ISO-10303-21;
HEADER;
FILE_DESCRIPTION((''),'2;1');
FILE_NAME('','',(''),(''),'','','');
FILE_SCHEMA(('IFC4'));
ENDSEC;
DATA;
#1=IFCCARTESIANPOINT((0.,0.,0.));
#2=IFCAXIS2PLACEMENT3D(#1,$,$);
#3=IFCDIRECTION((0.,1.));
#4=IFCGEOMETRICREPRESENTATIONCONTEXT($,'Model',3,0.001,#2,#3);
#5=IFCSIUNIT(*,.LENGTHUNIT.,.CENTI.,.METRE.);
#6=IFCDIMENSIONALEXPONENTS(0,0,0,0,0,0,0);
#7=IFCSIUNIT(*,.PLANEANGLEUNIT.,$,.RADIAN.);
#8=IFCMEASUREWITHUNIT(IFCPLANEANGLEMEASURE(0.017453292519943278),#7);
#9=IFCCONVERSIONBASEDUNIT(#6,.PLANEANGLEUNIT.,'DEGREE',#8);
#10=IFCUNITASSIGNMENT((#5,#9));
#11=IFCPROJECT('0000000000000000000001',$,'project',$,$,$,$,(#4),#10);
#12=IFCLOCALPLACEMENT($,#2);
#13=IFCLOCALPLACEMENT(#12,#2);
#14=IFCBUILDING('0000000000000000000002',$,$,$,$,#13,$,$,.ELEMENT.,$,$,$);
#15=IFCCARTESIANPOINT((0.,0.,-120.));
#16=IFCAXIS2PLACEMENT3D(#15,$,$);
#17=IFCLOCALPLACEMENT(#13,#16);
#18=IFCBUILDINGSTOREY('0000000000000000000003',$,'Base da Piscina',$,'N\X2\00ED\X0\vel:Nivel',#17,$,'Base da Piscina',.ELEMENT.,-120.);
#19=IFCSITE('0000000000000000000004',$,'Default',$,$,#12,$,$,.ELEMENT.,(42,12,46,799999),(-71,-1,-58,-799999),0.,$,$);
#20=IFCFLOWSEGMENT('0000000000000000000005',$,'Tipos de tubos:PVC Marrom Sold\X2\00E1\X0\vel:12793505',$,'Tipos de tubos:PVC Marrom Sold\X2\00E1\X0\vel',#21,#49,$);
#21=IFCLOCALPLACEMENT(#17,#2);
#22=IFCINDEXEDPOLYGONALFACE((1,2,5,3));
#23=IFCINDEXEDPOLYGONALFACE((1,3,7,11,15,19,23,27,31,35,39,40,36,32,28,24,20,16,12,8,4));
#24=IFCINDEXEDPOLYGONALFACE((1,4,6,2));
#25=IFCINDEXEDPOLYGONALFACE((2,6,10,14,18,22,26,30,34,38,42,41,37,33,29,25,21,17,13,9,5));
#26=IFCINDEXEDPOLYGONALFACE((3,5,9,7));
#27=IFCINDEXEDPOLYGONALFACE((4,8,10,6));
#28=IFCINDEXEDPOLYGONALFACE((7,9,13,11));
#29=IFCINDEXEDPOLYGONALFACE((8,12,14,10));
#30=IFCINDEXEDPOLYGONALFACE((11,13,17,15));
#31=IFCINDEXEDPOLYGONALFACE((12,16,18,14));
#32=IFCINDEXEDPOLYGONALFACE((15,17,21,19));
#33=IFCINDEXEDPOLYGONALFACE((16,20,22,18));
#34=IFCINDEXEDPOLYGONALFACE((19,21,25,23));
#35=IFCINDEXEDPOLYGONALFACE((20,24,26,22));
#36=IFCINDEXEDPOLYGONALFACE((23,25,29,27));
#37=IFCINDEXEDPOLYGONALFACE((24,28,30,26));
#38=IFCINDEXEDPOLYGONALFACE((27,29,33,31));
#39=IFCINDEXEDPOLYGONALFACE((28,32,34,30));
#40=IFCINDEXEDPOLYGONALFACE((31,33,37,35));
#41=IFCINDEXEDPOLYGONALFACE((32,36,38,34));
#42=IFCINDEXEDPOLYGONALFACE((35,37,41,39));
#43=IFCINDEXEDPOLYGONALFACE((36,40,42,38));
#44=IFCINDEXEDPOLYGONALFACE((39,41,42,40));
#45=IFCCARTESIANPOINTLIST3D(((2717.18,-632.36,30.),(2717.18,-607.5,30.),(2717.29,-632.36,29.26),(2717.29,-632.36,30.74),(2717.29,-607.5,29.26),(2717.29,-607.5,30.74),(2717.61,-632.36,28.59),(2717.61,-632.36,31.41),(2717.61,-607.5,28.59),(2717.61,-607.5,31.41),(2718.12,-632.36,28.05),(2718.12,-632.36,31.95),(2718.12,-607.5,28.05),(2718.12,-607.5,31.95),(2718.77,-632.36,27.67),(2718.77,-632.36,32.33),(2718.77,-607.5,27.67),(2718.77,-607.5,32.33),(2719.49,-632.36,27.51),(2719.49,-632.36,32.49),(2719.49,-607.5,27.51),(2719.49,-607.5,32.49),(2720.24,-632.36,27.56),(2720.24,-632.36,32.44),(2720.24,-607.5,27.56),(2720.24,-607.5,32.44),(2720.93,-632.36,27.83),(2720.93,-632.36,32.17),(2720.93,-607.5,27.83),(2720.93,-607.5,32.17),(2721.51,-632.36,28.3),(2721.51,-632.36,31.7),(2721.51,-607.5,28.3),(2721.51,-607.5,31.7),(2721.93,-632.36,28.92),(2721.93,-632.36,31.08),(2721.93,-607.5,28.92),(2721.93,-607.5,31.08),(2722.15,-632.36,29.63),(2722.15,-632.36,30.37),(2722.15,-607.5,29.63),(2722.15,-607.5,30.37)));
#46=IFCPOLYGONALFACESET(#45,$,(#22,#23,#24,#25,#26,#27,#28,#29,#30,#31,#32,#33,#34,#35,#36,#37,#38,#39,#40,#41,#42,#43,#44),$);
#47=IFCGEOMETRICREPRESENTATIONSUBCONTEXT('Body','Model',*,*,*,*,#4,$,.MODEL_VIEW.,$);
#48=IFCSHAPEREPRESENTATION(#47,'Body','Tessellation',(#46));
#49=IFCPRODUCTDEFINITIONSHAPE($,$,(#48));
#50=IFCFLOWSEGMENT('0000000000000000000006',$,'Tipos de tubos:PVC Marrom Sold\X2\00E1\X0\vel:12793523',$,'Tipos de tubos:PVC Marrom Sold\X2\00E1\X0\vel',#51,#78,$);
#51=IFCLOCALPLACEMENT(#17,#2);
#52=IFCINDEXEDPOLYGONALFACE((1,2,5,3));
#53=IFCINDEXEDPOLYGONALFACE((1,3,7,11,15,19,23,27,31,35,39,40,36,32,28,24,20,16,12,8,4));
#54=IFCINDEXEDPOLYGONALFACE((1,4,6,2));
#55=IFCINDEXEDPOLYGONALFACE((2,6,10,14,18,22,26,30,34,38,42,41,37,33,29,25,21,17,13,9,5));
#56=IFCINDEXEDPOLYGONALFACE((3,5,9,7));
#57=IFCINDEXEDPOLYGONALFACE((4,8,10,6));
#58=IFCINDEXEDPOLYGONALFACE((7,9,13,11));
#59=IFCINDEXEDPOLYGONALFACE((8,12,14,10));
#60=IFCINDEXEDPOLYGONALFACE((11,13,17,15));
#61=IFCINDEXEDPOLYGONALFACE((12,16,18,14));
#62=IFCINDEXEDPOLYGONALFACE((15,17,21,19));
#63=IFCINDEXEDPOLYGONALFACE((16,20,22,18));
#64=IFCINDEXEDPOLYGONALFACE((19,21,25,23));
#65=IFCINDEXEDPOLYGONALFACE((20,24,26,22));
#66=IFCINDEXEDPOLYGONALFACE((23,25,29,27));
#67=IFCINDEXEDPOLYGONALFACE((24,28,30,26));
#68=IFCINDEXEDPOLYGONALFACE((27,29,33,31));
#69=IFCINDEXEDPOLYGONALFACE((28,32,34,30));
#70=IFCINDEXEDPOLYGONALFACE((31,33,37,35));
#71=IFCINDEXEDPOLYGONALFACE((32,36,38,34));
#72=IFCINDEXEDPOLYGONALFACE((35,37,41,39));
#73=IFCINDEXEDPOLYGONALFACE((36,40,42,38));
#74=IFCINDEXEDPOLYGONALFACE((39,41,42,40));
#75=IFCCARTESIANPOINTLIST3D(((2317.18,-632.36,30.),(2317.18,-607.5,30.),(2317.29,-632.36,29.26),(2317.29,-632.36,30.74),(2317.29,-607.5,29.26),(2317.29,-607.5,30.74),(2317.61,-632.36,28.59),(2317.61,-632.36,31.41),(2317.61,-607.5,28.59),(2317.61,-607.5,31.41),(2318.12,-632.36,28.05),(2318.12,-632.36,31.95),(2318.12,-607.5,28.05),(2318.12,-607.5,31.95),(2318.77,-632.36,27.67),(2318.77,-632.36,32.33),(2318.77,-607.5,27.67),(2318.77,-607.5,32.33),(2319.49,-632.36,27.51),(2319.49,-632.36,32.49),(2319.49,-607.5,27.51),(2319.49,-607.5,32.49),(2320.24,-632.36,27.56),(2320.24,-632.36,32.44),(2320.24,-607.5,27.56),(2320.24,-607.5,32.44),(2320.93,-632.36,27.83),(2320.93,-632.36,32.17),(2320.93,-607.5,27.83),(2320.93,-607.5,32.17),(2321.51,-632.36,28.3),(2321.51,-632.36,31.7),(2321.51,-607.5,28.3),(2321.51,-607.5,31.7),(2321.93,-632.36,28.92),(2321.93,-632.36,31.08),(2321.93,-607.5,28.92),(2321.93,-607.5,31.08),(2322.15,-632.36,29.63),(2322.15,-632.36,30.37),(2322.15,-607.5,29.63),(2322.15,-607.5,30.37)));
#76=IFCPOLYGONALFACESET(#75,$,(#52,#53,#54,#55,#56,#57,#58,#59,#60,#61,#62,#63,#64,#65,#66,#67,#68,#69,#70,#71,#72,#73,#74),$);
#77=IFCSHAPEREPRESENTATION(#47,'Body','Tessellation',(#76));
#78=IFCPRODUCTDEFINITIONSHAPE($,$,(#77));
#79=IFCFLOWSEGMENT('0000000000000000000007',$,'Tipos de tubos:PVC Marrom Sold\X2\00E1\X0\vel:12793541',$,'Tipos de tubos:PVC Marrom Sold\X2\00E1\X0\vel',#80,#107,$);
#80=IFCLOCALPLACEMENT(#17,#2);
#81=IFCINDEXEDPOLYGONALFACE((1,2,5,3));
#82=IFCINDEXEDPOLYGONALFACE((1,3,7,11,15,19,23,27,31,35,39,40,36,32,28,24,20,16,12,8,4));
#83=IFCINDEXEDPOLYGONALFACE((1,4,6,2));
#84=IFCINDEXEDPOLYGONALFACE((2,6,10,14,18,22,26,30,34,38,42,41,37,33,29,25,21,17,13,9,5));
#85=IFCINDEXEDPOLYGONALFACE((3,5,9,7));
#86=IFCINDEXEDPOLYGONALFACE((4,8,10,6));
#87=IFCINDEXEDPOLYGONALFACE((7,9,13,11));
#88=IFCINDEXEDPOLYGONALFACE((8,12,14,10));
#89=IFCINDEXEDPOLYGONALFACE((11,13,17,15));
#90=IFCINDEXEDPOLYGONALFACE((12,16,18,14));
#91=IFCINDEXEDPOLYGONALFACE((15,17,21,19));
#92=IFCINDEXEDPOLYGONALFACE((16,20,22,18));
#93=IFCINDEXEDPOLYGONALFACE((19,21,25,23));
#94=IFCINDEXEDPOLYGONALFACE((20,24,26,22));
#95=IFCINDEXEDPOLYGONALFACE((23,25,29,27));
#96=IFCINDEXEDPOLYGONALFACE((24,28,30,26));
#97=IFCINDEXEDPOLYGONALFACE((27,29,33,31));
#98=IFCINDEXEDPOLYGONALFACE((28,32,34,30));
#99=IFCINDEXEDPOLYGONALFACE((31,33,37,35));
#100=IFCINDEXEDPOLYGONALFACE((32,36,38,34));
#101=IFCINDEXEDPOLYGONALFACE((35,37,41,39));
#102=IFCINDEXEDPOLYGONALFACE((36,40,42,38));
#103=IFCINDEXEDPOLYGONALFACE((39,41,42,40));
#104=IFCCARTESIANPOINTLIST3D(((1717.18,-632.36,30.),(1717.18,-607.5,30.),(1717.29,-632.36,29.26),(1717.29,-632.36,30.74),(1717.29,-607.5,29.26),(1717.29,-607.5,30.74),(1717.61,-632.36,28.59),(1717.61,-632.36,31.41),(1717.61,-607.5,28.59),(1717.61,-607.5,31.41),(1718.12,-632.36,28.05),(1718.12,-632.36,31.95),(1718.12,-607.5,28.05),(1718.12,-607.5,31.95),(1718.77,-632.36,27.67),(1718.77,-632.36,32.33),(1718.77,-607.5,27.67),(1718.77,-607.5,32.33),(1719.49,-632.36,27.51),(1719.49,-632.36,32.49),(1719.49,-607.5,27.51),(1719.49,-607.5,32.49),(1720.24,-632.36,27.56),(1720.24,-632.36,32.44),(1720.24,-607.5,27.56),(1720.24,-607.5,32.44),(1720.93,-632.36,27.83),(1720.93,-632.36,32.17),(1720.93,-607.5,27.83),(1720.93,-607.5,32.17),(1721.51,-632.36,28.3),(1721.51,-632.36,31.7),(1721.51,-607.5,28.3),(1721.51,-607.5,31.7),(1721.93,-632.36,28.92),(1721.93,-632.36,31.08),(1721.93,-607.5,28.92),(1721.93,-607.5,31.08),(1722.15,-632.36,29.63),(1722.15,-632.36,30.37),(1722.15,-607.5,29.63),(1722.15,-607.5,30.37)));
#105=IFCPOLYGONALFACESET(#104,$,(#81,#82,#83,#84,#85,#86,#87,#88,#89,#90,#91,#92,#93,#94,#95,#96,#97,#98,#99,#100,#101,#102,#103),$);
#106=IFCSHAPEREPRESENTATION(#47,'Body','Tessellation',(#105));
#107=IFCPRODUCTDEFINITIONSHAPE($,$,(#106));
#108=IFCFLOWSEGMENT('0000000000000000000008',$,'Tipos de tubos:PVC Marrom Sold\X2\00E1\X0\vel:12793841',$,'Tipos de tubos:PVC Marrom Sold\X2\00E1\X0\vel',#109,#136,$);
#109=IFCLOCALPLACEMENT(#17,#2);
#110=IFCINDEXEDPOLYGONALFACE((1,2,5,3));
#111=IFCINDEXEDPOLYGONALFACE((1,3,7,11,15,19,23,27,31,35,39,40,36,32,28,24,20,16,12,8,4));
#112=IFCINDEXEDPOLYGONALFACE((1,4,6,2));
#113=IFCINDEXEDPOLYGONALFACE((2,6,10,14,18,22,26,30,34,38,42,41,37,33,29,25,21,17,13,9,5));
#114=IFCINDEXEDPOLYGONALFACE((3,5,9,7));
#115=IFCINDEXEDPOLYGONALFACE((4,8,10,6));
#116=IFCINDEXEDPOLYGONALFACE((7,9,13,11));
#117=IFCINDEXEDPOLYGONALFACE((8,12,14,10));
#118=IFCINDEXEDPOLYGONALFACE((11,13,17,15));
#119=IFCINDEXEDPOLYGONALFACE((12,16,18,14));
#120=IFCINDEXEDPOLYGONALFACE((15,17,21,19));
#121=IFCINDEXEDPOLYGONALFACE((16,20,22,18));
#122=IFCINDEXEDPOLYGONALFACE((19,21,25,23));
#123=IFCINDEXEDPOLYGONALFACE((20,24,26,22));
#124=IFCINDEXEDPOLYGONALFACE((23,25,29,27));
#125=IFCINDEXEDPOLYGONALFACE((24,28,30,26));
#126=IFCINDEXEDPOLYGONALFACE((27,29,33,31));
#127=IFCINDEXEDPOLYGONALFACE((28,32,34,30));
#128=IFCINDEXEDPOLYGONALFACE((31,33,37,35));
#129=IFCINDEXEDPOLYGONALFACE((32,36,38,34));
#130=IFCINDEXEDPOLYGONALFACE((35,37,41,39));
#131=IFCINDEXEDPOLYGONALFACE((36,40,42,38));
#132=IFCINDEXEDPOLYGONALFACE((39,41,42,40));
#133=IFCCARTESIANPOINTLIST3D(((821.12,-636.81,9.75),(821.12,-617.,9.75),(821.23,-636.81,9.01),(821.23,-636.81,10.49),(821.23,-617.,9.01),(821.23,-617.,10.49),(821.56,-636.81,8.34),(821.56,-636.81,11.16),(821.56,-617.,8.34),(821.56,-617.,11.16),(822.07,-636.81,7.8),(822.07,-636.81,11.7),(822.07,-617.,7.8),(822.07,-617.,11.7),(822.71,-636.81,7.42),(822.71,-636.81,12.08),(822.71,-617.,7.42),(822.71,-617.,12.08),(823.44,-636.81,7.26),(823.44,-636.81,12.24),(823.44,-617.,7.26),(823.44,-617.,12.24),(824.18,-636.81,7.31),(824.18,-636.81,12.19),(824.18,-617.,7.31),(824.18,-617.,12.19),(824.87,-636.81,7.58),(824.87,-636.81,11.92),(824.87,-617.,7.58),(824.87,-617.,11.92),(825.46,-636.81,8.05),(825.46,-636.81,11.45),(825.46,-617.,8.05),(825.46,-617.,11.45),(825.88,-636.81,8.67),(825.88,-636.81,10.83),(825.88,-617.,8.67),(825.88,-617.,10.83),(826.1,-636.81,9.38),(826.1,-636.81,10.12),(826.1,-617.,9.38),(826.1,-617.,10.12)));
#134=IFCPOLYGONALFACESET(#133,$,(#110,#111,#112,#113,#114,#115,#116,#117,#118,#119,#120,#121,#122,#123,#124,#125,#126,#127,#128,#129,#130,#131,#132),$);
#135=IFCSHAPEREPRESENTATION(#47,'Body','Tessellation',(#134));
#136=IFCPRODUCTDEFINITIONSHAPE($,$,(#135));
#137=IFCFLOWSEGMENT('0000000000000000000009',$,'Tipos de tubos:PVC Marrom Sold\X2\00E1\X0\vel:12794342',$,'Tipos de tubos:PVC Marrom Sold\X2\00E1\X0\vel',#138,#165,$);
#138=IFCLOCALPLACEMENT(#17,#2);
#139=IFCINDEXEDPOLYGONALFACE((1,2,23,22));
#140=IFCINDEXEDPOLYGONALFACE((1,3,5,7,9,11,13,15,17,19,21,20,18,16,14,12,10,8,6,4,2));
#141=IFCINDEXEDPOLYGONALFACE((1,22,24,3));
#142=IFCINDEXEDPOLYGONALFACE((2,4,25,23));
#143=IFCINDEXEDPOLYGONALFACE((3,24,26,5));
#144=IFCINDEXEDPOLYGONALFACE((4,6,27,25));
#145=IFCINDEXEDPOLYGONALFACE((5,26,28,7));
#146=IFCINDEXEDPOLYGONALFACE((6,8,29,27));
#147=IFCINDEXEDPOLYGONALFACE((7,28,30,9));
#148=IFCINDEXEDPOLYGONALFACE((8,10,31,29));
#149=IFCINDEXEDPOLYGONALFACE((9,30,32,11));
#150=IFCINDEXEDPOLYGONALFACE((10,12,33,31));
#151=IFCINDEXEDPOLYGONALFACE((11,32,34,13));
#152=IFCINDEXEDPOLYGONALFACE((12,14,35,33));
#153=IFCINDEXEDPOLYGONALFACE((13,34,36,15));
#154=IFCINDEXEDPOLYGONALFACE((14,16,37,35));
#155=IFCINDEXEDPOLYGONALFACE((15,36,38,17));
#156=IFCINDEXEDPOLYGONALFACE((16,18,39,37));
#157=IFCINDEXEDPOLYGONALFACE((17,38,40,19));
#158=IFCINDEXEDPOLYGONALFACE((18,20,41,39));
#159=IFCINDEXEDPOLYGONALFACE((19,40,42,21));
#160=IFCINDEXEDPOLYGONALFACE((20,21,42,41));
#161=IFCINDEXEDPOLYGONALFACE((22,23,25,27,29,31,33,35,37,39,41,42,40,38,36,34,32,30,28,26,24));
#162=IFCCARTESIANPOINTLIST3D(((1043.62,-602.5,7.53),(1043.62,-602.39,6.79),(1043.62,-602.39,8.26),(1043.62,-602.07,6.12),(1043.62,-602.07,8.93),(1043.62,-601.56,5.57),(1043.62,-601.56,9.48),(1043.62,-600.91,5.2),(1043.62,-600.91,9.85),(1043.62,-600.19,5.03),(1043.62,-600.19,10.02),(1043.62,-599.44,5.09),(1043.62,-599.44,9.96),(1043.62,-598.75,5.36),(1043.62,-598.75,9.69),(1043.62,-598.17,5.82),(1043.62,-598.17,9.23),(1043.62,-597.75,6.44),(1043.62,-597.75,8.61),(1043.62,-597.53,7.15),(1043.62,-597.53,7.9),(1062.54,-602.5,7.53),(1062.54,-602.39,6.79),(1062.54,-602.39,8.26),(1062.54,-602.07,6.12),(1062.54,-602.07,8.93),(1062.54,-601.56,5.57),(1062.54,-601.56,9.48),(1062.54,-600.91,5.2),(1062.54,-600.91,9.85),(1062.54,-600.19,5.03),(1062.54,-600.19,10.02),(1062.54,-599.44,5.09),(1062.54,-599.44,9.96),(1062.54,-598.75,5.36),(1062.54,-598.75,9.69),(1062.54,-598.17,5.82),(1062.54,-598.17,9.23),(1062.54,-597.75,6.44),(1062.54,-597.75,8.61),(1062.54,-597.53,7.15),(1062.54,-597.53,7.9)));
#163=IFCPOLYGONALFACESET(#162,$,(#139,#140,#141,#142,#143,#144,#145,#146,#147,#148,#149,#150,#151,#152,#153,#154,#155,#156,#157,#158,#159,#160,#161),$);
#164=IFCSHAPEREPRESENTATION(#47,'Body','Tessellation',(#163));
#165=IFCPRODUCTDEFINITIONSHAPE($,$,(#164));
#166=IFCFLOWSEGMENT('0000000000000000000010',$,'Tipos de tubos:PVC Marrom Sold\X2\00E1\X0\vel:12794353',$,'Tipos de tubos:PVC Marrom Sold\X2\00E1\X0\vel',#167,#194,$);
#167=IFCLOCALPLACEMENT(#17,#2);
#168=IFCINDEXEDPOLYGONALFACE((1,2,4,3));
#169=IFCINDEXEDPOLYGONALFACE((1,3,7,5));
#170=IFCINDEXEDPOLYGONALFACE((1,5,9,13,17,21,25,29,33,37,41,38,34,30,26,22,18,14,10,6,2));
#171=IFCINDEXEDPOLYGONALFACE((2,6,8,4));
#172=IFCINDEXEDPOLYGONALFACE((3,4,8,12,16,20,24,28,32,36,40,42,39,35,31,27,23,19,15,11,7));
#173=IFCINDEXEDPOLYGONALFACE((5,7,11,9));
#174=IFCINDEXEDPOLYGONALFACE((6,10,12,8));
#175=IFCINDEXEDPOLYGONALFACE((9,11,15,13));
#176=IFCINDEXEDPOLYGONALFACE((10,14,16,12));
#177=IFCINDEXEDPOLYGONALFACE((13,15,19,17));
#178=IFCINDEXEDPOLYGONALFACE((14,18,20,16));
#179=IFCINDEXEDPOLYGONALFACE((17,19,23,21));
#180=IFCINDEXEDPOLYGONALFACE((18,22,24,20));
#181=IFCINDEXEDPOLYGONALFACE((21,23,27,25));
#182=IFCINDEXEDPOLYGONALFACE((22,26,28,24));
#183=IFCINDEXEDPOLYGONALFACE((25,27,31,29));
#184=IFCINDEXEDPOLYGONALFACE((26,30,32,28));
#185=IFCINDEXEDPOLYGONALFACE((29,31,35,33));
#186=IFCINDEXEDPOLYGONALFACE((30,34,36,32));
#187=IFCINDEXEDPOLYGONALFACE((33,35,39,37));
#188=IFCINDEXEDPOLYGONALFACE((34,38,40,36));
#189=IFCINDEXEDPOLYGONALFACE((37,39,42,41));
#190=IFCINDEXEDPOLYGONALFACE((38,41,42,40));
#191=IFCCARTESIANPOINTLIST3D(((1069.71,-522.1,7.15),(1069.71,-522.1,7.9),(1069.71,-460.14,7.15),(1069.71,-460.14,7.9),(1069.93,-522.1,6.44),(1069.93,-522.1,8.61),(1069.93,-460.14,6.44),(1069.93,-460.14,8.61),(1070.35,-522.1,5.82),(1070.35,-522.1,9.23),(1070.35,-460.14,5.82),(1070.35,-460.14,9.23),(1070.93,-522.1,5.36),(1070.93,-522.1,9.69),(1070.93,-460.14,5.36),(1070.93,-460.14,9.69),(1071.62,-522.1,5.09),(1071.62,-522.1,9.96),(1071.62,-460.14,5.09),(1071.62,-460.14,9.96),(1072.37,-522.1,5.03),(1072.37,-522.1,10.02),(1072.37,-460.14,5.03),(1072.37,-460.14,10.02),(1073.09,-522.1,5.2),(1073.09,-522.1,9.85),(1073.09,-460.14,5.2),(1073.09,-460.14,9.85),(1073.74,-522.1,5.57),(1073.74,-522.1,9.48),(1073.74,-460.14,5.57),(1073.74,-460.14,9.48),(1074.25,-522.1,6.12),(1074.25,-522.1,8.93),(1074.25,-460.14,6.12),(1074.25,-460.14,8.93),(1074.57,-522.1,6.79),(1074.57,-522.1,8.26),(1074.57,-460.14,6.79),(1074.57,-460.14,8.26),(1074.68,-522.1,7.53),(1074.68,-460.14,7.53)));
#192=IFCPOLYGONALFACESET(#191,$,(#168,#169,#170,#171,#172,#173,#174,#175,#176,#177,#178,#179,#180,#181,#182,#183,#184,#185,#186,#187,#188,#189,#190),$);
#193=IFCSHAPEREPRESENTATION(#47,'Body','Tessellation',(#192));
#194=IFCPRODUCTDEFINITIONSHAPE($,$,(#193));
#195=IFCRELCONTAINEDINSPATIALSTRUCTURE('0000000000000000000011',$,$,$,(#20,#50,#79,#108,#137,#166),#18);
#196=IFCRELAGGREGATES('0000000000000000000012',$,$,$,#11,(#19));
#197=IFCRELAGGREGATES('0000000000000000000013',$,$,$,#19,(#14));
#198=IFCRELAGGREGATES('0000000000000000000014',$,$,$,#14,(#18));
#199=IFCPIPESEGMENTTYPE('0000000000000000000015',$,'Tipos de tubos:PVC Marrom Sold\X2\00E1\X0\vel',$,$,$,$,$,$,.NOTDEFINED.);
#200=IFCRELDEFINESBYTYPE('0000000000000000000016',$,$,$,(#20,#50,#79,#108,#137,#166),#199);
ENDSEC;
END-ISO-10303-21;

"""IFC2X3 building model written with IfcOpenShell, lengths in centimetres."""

from ifc_helpers import new_model, entity, si_unit, converted_unit, direction, frame, frame_2d, origin, origin_2d_with_axis, place, context, subcontext, project, spatial, circle, extrude, type_object, element, save


model = new_model("IFC2X3")

# Units and contexts
model_context = context("Model", 3, precision=0.001, world=origin(), true_north=direction((0.0, 1.0)))
body_context = subcontext(model_context, "Body", "Model", "MODEL_VIEW")
ifc_project = project(units=[si_unit("LENGTHUNIT", "METRE", prefix="CENTI"), converted_unit("PLANEANGLEUNIT", "DEGREE", entity("IfcPlaneAngleMeasure", 0.017453292519943278), si_unit("PLANEANGLEUNIT", "RADIAN"), dimensions=[0, 0, 0, 0, 0, 0, 0])], contexts=[model_context])

# Site, building, storey
site_placement = place(None, origin())
site = spatial("IfcSite", under=ifc_project, at=site_placement, Name="Default", CompositionType="ELEMENT", RefLatitude=(42, 12, 46, 799999), RefLongitude=(-71, -1, -58, -799999), RefElevation=0.0)
building_placement = place(site_placement, origin())
building = spatial("IfcBuilding", under=site, at=building_placement, CompositionType="ELEMENT")
storey_placement = place(building_placement, frame((0.0, 0.0, -120.0)))
storey = spatial("IfcBuildingStorey", under=building, at=storey_placement, Name="Base da Piscina", ObjectType="Nível:Nivel", LongName="Base da Piscina", CompositionType="ELEMENT", Elevation=-120.0)

# Flow segments
pipe_segment_type = type_object("IfcPipeSegmentType", Name="Tipos de tubos:PVC Marrom Soldável", PredefinedType="NOTDEFINED")
flow_segment_1_placement = place(storey_placement, origin())
element("IfcFlowSegment", 1, at=flow_segment_1_placement, inside=storey, type_object=pipe_segment_type, Name="Tipos de tubos:PVC Marrom Soldável:12793505", ObjectType="Tipos de tubos:PVC Marrom Soldável", context=body_context, shape_type="SweptSolid", body=[
    extrude(circle(Radius=2.5, at=origin_2d_with_axis()), frame((2719.68, -632.36, 30.0), z_axis=(0.0, 1.0, 0.0), x_axis=(-1.0, 0.0, 0.0)), (0.0, 0.0, 1.0), 24.86),
])
flow_segment_2_placement = place(storey_placement, origin())
element("IfcFlowSegment", 2, at=flow_segment_2_placement, inside=storey, type_object=pipe_segment_type, Name="Tipos de tubos:PVC Marrom Soldável:12793523", ObjectType="Tipos de tubos:PVC Marrom Soldável", context=body_context, shape_type="SweptSolid", body=[
    extrude(circle(Radius=2.5, at=origin_2d_with_axis()), frame((2319.68, -632.36, 30.0), z_axis=(0.0, 1.0, 0.0), x_axis=(-1.0, 0.0, 0.0)), (0.0, 0.0, 1.0), 24.86),
])
flow_segment_3_placement = place(storey_placement, origin())
element("IfcFlowSegment", 3, at=flow_segment_3_placement, inside=storey, type_object=pipe_segment_type, Name="Tipos de tubos:PVC Marrom Soldável:12793541", ObjectType="Tipos de tubos:PVC Marrom Soldável", context=body_context, shape_type="SweptSolid", body=[
    extrude(circle(Radius=2.5, at=origin_2d_with_axis()), frame((1719.68, -632.36, 30.0), z_axis=(0.0, 1.0, 0.0), x_axis=(-1.0, 0.0, 0.0)), (0.0, 0.0, 1.0), 24.86),
])
flow_segment_4_placement = place(storey_placement, origin())
element("IfcFlowSegment", 4, at=flow_segment_4_placement, inside=storey, type_object=pipe_segment_type, Name="Tipos de tubos:PVC Marrom Soldável:12793841", ObjectType="Tipos de tubos:PVC Marrom Soldável", context=body_context, shape_type="SweptSolid", body=[
    extrude(circle(Radius=2.5, at=frame_2d((0.0, 0.0), x_axis=(1.0, 0.0))), frame((823.62, -636.81, 9.75), z_axis=(0.0, 1.0, 0.0), x_axis=(-1.0, 0.0, 0.0)), (0.0, 0.0, 1.0), 19.81),
])
flow_segment_5_placement = place(storey_placement, origin())
element("IfcFlowSegment", 5, at=flow_segment_5_placement, inside=storey, type_object=pipe_segment_type, Name="Tipos de tubos:PVC Marrom Soldável:12794342", ObjectType="Tipos de tubos:PVC Marrom Soldável", context=body_context, shape_type="SweptSolid", body=[
    extrude(circle(Radius=2.5, at=origin_2d_with_axis()), frame((1043.62, -600.0, 7.53), z_axis=(1.0, 0.0, 0.0), x_axis=(0.0, -1.0, 0.0)), (0.0, 0.0, 1.0), 18.91),
])
flow_segment_6_placement = place(storey_placement, origin())
element("IfcFlowSegment", 6, at=flow_segment_6_placement, inside=storey, type_object=pipe_segment_type, Name="Tipos de tubos:PVC Marrom Soldável:12794353", ObjectType="Tipos de tubos:PVC Marrom Soldável", context=body_context, shape_type="SweptSolid", body=[
    extrude(circle(Radius=2.5, at=origin_2d_with_axis()), frame((1072.18, -522.1, 7.53), z_axis=(0.0, 1.0, 0.0), x_axis=(1.0, 0.0, 0.0)), (0.0, 0.0, 1.0), 61.96),
])

save(model, "model.ifc")
